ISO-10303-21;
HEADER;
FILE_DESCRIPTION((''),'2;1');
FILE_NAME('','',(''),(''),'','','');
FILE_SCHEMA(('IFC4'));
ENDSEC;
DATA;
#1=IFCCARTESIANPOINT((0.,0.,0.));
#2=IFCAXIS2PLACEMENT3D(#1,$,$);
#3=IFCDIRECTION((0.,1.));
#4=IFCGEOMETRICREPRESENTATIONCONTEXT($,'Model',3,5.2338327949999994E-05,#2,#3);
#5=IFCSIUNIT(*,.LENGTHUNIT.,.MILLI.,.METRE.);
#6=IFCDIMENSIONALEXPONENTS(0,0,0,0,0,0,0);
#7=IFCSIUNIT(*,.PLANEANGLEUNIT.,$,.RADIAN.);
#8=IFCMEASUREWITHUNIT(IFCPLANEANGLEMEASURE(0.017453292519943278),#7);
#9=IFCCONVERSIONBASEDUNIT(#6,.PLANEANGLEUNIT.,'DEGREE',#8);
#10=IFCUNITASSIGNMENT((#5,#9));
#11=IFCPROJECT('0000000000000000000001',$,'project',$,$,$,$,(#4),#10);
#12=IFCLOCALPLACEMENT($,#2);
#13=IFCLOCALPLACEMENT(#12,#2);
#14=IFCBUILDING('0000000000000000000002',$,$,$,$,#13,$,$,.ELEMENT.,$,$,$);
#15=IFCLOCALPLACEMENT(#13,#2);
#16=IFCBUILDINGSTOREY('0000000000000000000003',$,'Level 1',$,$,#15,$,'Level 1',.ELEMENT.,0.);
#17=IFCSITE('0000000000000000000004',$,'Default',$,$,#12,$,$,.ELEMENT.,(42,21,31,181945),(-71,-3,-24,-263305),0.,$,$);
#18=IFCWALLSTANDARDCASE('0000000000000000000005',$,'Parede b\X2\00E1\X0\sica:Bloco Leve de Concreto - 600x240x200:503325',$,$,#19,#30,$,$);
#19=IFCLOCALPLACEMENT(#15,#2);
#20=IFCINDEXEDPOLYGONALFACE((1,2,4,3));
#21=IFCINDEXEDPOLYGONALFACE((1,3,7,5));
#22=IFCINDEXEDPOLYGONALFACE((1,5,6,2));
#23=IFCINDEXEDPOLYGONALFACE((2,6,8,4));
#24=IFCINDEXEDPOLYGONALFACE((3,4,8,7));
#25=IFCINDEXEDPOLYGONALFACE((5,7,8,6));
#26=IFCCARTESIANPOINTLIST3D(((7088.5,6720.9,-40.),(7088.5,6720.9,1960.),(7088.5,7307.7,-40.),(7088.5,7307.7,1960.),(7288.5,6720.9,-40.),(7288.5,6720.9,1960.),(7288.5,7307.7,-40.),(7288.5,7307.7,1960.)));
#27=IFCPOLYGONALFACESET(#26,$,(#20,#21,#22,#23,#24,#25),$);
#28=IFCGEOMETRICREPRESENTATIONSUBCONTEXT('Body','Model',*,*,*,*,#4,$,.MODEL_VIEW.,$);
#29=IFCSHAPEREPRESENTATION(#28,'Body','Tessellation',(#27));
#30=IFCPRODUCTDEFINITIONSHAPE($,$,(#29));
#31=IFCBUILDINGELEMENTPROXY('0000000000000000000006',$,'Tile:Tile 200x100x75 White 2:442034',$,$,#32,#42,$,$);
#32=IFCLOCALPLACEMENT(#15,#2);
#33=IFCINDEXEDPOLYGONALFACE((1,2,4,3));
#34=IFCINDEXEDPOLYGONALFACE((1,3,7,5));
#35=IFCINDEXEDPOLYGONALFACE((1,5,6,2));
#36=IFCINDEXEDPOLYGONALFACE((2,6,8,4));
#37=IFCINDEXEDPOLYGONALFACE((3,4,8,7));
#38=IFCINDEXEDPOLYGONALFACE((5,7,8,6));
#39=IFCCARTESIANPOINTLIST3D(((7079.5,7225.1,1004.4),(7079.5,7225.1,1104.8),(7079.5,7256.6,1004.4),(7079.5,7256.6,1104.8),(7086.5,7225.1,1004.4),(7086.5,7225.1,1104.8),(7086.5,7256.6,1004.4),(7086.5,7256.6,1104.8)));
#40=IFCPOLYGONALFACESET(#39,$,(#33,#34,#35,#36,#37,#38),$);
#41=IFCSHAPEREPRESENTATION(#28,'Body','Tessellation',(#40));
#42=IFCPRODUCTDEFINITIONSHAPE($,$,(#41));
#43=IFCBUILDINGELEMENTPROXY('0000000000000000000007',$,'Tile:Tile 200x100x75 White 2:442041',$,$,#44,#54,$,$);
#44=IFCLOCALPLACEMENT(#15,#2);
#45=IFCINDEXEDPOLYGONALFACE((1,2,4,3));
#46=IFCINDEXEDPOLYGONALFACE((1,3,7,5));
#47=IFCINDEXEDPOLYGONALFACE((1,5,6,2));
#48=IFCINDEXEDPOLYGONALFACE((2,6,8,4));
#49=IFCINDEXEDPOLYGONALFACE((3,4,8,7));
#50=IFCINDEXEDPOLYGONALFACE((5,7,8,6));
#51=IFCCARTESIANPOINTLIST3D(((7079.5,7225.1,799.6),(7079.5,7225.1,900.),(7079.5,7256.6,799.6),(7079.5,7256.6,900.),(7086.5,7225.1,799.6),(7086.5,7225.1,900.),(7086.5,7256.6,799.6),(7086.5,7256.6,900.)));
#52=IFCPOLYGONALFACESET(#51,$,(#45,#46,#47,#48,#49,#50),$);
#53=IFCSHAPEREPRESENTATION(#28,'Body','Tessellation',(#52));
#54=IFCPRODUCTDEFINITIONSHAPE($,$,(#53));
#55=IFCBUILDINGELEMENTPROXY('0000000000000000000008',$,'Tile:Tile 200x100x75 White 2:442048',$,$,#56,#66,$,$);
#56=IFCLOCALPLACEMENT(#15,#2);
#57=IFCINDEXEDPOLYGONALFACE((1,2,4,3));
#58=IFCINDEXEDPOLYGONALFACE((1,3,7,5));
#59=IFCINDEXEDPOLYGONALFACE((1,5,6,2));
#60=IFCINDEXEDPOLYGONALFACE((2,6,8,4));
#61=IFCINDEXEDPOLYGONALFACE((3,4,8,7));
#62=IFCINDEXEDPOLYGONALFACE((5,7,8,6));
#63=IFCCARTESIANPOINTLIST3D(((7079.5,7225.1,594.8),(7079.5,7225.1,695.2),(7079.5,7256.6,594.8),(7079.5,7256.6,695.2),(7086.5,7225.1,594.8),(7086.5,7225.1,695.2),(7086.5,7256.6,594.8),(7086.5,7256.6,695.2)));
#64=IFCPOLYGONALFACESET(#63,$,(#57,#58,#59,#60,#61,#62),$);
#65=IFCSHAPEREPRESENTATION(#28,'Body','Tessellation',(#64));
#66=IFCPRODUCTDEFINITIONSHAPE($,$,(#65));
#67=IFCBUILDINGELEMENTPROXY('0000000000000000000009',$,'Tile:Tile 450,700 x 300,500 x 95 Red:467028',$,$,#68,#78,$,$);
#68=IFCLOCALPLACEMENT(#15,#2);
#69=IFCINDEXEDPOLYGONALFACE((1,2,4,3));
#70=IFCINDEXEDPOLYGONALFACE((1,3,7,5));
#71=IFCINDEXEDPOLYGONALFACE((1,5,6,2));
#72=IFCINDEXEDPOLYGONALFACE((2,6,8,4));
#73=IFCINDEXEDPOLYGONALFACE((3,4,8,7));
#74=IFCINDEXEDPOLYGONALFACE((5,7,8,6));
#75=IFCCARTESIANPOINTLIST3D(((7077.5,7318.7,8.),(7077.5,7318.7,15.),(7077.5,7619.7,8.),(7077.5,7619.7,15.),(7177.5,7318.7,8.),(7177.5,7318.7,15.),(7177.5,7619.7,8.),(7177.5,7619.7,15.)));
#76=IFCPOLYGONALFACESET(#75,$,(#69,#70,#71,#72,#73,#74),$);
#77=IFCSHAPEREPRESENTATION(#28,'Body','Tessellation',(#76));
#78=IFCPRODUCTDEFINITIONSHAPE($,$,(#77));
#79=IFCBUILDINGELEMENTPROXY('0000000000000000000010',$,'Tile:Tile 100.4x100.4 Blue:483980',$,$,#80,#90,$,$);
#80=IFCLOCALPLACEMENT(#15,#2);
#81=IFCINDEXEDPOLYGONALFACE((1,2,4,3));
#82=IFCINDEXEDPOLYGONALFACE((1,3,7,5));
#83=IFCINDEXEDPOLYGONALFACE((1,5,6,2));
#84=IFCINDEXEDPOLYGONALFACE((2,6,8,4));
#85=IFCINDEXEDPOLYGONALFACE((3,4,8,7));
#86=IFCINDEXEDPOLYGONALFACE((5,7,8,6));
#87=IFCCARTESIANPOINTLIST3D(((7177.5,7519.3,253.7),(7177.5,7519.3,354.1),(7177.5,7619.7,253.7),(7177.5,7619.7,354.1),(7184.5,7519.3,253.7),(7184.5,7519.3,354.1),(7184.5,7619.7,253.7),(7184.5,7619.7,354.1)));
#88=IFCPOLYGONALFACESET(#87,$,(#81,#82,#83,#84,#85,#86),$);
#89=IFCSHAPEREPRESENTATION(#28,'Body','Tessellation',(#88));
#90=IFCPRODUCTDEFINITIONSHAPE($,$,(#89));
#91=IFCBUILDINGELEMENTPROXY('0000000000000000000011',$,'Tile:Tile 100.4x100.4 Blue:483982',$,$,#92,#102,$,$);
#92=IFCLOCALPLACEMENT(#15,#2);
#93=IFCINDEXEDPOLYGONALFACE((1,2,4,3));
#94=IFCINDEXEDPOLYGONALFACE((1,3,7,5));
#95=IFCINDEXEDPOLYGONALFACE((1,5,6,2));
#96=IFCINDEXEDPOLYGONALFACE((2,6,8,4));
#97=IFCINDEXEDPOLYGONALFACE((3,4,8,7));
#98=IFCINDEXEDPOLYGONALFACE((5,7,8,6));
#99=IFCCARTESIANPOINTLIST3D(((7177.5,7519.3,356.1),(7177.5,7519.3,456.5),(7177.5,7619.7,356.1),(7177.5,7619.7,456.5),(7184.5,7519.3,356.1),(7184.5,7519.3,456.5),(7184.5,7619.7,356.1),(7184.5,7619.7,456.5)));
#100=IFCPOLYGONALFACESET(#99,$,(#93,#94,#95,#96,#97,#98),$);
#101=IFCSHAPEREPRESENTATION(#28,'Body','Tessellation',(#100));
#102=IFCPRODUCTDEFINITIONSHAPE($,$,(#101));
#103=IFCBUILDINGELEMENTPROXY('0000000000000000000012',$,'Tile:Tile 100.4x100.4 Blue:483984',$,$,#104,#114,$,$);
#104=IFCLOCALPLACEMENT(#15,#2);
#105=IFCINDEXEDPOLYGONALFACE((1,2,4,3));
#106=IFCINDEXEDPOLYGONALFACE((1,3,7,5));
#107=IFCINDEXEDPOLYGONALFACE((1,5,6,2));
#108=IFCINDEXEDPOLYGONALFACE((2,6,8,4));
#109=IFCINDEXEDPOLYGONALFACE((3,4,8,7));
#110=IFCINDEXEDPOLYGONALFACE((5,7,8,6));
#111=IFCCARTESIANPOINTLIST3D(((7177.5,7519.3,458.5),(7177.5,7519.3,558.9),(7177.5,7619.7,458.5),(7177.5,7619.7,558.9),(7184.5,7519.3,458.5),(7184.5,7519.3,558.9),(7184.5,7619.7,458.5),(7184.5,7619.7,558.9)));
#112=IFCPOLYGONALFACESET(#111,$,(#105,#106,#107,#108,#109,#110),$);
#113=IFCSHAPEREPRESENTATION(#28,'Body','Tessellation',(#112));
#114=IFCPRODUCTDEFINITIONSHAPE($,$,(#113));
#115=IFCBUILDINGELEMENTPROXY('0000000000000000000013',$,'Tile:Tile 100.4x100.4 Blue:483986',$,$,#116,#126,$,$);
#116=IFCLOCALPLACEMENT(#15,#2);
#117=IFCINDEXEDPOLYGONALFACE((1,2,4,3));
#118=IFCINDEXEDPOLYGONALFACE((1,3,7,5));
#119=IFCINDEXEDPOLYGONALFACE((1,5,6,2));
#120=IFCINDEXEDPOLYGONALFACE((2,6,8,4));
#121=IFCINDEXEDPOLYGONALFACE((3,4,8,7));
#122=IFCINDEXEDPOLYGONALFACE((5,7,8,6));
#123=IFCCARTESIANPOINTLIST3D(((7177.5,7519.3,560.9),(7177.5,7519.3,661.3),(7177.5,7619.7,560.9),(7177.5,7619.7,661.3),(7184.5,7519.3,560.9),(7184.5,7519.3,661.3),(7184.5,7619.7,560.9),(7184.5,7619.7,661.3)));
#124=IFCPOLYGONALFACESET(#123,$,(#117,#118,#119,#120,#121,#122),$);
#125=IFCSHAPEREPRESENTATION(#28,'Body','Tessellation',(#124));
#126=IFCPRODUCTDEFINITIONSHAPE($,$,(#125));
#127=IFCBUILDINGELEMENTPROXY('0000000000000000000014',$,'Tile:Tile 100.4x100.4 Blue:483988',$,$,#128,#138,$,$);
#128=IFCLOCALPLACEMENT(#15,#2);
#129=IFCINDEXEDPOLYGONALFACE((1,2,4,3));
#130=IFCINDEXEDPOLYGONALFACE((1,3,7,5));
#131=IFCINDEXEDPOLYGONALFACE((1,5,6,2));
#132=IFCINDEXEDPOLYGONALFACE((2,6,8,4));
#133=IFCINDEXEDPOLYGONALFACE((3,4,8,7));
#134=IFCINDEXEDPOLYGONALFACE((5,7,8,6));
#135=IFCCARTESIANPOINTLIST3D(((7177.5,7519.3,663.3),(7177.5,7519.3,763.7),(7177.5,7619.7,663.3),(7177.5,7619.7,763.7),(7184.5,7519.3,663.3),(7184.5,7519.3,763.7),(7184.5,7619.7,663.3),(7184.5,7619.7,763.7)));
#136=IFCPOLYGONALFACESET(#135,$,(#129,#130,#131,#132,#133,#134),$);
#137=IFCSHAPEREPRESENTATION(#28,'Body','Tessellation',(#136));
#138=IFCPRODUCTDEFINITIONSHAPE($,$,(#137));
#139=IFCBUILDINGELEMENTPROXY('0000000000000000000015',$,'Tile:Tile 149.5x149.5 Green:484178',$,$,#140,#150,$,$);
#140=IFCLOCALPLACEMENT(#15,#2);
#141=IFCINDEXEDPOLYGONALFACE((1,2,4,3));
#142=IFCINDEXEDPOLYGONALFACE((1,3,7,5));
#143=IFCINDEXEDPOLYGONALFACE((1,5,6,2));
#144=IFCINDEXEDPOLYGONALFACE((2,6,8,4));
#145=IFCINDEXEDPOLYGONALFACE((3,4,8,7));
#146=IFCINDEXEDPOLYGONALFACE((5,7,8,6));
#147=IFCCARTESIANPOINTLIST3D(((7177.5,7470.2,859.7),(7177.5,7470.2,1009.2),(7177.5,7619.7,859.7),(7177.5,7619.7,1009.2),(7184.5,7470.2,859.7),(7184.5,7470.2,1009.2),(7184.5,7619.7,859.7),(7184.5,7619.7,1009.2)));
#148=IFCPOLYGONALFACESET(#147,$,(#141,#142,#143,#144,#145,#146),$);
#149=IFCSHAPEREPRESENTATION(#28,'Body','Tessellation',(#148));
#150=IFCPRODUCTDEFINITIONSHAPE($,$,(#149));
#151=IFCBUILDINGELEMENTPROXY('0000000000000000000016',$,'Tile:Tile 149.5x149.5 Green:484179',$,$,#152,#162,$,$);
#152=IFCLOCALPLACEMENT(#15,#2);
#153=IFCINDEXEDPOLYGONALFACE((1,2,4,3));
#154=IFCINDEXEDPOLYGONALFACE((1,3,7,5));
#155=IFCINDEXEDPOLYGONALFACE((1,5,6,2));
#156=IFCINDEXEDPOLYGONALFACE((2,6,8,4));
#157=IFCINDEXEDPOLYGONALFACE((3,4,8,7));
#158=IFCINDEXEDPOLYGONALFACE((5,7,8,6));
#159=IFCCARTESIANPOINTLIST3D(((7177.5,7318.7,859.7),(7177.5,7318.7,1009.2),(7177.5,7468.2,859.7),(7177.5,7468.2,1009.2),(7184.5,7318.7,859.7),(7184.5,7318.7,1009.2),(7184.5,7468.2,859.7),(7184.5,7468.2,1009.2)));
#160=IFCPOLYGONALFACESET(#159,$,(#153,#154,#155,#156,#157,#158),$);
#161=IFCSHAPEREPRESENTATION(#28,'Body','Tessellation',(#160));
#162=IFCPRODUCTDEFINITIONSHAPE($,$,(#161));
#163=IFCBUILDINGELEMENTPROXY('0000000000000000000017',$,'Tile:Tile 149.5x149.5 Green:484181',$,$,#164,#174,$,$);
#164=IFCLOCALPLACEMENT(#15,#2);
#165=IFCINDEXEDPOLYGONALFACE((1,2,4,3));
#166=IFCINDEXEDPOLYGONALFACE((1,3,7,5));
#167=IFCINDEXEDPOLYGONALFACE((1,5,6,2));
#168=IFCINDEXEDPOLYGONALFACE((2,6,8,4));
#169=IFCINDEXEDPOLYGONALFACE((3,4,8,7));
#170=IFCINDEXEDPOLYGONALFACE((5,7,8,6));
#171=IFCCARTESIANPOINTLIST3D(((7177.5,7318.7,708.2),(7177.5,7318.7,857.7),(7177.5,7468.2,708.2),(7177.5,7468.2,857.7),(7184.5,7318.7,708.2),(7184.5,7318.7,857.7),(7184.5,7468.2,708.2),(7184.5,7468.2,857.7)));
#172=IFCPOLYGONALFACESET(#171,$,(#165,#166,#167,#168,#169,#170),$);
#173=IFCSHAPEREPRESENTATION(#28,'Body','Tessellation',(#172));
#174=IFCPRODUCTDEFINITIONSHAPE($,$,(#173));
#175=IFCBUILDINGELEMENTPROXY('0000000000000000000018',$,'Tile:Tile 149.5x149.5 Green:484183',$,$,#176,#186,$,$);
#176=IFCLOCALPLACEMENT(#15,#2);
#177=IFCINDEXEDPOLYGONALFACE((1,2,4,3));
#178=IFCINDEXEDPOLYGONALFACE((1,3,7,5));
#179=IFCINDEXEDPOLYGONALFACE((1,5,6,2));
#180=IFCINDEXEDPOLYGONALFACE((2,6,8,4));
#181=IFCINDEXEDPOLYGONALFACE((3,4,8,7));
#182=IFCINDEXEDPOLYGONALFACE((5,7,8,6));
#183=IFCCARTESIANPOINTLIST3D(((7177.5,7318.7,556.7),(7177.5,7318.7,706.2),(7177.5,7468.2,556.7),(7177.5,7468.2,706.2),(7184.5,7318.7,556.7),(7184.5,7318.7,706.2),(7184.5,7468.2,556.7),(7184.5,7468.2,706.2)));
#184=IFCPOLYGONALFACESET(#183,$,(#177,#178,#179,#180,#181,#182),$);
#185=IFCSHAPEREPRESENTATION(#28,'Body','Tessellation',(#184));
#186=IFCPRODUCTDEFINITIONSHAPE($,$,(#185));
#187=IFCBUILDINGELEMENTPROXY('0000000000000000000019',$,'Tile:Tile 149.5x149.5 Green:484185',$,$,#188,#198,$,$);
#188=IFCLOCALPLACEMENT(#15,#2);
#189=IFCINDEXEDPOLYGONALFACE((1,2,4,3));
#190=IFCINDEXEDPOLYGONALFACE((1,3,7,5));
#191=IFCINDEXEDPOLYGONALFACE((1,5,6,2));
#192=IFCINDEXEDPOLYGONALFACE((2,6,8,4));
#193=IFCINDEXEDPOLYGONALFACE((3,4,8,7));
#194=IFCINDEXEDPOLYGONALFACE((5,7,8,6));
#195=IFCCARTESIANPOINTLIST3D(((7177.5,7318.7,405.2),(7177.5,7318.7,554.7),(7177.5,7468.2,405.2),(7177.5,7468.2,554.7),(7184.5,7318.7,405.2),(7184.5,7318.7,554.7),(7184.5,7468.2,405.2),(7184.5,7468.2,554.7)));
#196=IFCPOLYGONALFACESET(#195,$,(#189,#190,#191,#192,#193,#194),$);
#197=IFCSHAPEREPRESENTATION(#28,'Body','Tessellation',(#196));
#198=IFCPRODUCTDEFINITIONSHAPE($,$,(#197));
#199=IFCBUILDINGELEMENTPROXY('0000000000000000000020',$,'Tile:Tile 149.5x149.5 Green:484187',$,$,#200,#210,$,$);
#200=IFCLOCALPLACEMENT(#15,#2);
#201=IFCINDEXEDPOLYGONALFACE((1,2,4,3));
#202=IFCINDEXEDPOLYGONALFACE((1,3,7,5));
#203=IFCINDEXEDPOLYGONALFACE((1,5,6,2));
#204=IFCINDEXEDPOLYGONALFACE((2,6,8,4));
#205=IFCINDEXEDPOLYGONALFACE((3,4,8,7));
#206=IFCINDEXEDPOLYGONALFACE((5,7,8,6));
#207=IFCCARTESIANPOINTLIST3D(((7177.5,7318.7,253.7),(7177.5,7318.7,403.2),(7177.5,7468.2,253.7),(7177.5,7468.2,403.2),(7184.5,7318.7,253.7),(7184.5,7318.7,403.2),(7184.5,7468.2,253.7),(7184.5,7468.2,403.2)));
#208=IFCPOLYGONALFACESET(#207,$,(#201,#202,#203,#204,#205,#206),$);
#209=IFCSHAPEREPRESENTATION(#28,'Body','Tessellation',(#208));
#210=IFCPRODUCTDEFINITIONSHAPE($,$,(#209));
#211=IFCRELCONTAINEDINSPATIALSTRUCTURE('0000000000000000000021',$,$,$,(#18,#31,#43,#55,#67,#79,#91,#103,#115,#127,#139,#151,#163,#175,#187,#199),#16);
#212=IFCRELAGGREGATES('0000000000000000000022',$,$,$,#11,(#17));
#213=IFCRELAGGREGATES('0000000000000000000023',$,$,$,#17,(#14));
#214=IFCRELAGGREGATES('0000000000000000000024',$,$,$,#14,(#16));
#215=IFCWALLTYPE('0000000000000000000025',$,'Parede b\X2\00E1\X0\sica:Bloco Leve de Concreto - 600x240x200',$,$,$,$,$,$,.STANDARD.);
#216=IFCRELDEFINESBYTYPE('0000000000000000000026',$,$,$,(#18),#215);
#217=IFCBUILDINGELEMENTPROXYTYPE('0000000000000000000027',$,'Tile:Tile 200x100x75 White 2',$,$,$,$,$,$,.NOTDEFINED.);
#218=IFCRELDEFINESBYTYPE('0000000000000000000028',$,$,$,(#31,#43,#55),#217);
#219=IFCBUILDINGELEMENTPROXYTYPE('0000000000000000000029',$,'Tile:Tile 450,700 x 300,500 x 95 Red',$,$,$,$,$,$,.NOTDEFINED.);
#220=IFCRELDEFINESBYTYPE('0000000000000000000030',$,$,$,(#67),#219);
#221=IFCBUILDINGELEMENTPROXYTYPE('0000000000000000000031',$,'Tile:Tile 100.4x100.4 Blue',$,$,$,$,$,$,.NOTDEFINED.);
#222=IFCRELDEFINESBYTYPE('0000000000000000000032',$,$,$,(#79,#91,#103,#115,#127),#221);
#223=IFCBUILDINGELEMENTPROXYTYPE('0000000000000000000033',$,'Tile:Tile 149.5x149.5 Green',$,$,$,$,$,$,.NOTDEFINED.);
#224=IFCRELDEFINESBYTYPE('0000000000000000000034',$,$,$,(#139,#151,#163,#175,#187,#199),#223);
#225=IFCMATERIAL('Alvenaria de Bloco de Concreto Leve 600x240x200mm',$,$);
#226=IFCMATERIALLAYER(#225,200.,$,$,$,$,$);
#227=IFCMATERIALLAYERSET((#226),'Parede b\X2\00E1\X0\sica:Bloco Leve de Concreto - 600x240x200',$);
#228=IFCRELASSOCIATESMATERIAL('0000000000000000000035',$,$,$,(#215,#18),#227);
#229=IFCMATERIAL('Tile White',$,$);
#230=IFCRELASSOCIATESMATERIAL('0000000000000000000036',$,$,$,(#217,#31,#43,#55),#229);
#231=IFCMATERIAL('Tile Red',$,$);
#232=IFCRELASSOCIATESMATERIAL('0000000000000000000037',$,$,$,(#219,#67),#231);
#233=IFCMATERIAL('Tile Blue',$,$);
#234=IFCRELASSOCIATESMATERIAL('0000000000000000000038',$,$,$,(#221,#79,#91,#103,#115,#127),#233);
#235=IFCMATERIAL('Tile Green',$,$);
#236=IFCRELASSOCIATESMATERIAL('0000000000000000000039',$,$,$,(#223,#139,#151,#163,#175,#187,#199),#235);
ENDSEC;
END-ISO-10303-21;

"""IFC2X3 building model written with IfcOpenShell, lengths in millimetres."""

from ifc_helpers import new_model, entity, si_unit, converted_unit, direction, frame, frame_2d, origin, origin_2d_with_axis, place, context, subcontext, project, spatial, rectangle, extrude, source, transform, mapped, material, layer, layer_set, layer_usage, type_object, type_shapes, element, save


model = new_model("IFC2X3")

# Units and contexts
model_context = context("Model", 3, precision=5.2338327949999994e-05, world=origin(), true_north=direction((0.0, 1.0)))
body_context = subcontext(model_context, "Body", "Model", "MODEL_VIEW")
ifc_project = project(units=[si_unit("LENGTHUNIT", "METRE", prefix="MILLI"), converted_unit("PLANEANGLEUNIT", "DEGREE", entity("IfcPlaneAngleMeasure", 0.017453292519943278), si_unit("PLANEANGLEUNIT", "RADIAN"), dimensions=[0, 0, 0, 0, 0, 0, 0])], contexts=[model_context])

# Site, building, storey
site_placement = place(None, origin())
site = spatial("IfcSite", under=ifc_project, at=site_placement, Name="Default", CompositionType="ELEMENT", RefLatitude=(42, 21, 31, 181945), RefLongitude=(-71, -3, -24, -263305), RefElevation=0.0)
building_placement = place(site_placement, origin())
building = spatial("IfcBuilding", under=site, at=building_placement, CompositionType="ELEMENT")
storey_placement = place(building_placement, origin())
storey = spatial("IfcBuildingStorey", under=building, at=storey_placement, Name="Level 1", LongName="Level 1", CompositionType="ELEMENT", Elevation=0.0)

# Wall
ifc_material_1 = material(Name="Alvenaria de Bloco de Concreto Leve 600x240x200mm")
ifc_layer = layer(ifc_material_1, 200.0)
ifc_layer_set = layer_set([ifc_layer], Name="Parede básica:Bloco Leve de Concreto - 600x240x200")
ifc_layer_usage = layer_usage(ifc_layer_set, "AXIS2", "NEGATIVE", 100.0)
wall_type = type_object("IfcWallType", Name="Parede básica:Bloco Leve de Concreto - 600x240x200", PredefinedType="STANDARD", material=ifc_layer_set)
wall_placement = place(storey_placement, frame((7188.5, 7307.7, -40.0), z_axis=(0.0, 0.0, 1.0), x_axis=(0.0, -1.0, 0.0)))
element("IfcWallStandardCase", 1, at=wall_placement, inside=storey, type_object=wall_type, material=ifc_layer_usage, Name="Parede básica:Bloco Leve de Concreto - 600x240x200:503325", context=body_context, shape_type="SweptSolid", body=[
    extrude(rectangle(XDim=586.8, YDim=200.0, at=frame_2d((293.4, 0.0), x_axis=(-1.0, 0.0))), origin(), (0.0, 0.0, 1.0), 2000.0),
])

# Building element proxies
ifc_material_2 = material(Name="Tile White")
building_element_proxy_type_1 = type_object("IfcBuildingElementProxyType", Name="Tile:Tile 200x100x75 White 2", PredefinedType="NOTDEFINED", material=ifc_material_2)
shared_shape_1 = source(origin(), body_context, "Body", "SweptSolid", [
    extrude(rectangle(XDim=100.4, YDim=31.5, at=origin_2d_with_axis()), frame((-50.2, 15.8, 0.0)), (0.0, 0.0, 1.0), 7.0),
])
type_shapes(building_element_proxy_type_1, [shared_shape_1])
for number, where, z_axis, x_axis, name in (
    (2, (7086.5, 7225.1, 1104.8), (-1.0, 0.0, 0.0), (0.0, 0.0, 1.0), "Tile:Tile 200x100x75 White 2:442034"),
    (3, (7086.5, 7225.1, 900.0), (-1.0, 0.0, 0.0), (0.0, 0.0, 1.0), "Tile:Tile 200x100x75 White 2:442041"),
    (4, (7086.5, 7225.1, 695.2), (-1.0, 0.0, 0.0), (0.0, 0.0, 1.0), "Tile:Tile 200x100x75 White 2:442048"),
):
    element("IfcBuildingElementProxy", number, at=place(storey_placement, frame(where, z_axis=z_axis, x_axis=x_axis)), inside=storey, type_object=building_element_proxy_type_1, material=ifc_material_2, Name=name, context=body_context, shape_type="MappedRepresentation", body=[
        mapped(shared_shape_1, transform((0.0, 0.0, 0.0), scale=1.0)),
    ])
ifc_material_3 = material(Name="Tile Red")
building_element_proxy_type_2 = type_object("IfcBuildingElementProxyType", Name="Tile:Tile 450,700 x 300,500 x 95 Red", PredefinedType="NOTDEFINED", material=ifc_material_3)
shared_shape_2 = source(origin(), body_context, "Body", "SweptSolid", [
    extrude(rectangle(XDim=100.0, YDim=301.0, at=frame_2d((0.0, 0.0), x_axis=(1.0, 0.0))), frame((-50.0, -150.5, 0.0), z_axis=(0.0, 0.0, 1.0), x_axis=(-1.0, 0.0, 0.0)), (0.0, 0.0, 1.0), 7.0),
])
type_shapes(building_element_proxy_type_2, [shared_shape_2])
proxy_1_placement = place(storey_placement, frame((7177.5, 7619.7, 8.0)))
element("IfcBuildingElementProxy", 5, at=proxy_1_placement, inside=storey, type_object=building_element_proxy_type_2, material=ifc_material_3, Name="Tile:Tile 450,700 x 300,500 x 95 Red:467028", context=body_context, shape_type="MappedRepresentation", body=[
    mapped(shared_shape_2, transform((0.0, 0.0, 0.0), scale=1.0)),
])
ifc_material_4 = material(Name="Tile Blue")
building_element_proxy_type_3 = type_object("IfcBuildingElementProxyType", Name="Tile:Tile 100.4x100.4 Blue", PredefinedType="NOTDEFINED", material=ifc_material_4)
shared_shape_3 = source(origin(), body_context, "Body", "SweptSolid", [
    extrude(rectangle(XDim=100.4, YDim=100.4, at=origin_2d_with_axis()), frame((-50.2, -50.2, 0.0), z_axis=(0.0, 0.0, 1.0), x_axis=(0.0, -1.0, 0.0)), (0.0, 0.0, 1.0), 7.0),
])
type_shapes(building_element_proxy_type_3, [shared_shape_3])
for number, where, z_axis, x_axis, name in (
    (6, (7184.5, 7619.7, 253.7), (-1.0, 0.0, 0.0), (0.0, 1.0, 0.0), "Tile:Tile 100.4x100.4 Blue:483980"),
    (7, (7184.5, 7619.7, 356.1), (-1.0, 0.0, 0.0), (0.0, 1.0, 0.0), "Tile:Tile 100.4x100.4 Blue:483982"),
    (8, (7184.5, 7619.7, 458.5), (-1.0, 0.0, 0.0), (0.0, 1.0, 0.0), "Tile:Tile 100.4x100.4 Blue:483984"),
    (9, (7184.5, 7619.7, 560.9), (-1.0, 0.0, 0.0), (0.0, 1.0, 0.0), "Tile:Tile 100.4x100.4 Blue:483986"),
    (10, (7184.5, 7619.7, 663.3), (-1.0, 0.0, 0.0), (0.0, 1.0, 0.0), "Tile:Tile 100.4x100.4 Blue:483988"),
):
    element("IfcBuildingElementProxy", number, at=place(storey_placement, frame(where, z_axis=z_axis, x_axis=x_axis)), inside=storey, type_object=building_element_proxy_type_3, material=ifc_material_4, Name=name, context=body_context, shape_type="MappedRepresentation", body=[
        mapped(shared_shape_3, transform((0.0, 0.0, 0.0), scale=1.0)),
    ])
ifc_material_5 = material(Name="Tile Green")
building_element_proxy_type_4 = type_object("IfcBuildingElementProxyType", Name="Tile:Tile 149.5x149.5 Green", PredefinedType="NOTDEFINED", material=ifc_material_5)
shared_shape_4 = source(origin(), body_context, "Body", "SweptSolid", [
    extrude(rectangle(XDim=149.5, YDim=149.5, at=origin_2d_with_axis()), frame((-74.7, -74.8, 0.0), z_axis=(0.0, 0.0, 1.0), x_axis=(0.0, -1.0, 0.0)), (0.0, 0.0, 1.0), 7.0),
])
type_shapes(building_element_proxy_type_4, [shared_shape_4])
for number, where, z_axis, x_axis, name in (
    (11, (7184.5, 7619.7, 1009.2), (-1.0, 0.0, 0.0), (0.0, 0.0, 1.0), "Tile:Tile 149.5x149.5 Green:484178"),
    (12, (7184.5, 7468.2, 1009.2), (-1.0, 0.0, 0.0), (0.0, 0.0, 1.0), "Tile:Tile 149.5x149.5 Green:484179"),
    (13, (7184.5, 7468.2, 857.7), (-1.0, 0.0, 0.0), (0.0, 0.0, 1.0), "Tile:Tile 149.5x149.5 Green:484181"),
    (14, (7184.5, 7468.2, 706.2), (-1.0, 0.0, 0.0), (0.0, 0.0, 1.0), "Tile:Tile 149.5x149.5 Green:484183"),
    (15, (7184.5, 7468.2, 554.7), (-1.0, 0.0, 0.0), (0.0, 0.0, 1.0), "Tile:Tile 149.5x149.5 Green:484185"),
    (16, (7184.5, 7468.2, 403.2), (-1.0, 0.0, 0.0), (0.0, 0.0, 1.0), "Tile:Tile 149.5x149.5 Green:484187"),
):
    element("IfcBuildingElementProxy", number, at=place(storey_placement, frame(where, z_axis=z_axis, x_axis=x_axis)), inside=storey, type_object=building_element_proxy_type_4, material=ifc_material_5, Name=name, context=body_context, shape_type="MappedRepresentation", body=[
        mapped(shared_shape_4, transform((0.0, 0.0, 0.0), scale=1.0)),
    ])

save(model, "model.ifc")
